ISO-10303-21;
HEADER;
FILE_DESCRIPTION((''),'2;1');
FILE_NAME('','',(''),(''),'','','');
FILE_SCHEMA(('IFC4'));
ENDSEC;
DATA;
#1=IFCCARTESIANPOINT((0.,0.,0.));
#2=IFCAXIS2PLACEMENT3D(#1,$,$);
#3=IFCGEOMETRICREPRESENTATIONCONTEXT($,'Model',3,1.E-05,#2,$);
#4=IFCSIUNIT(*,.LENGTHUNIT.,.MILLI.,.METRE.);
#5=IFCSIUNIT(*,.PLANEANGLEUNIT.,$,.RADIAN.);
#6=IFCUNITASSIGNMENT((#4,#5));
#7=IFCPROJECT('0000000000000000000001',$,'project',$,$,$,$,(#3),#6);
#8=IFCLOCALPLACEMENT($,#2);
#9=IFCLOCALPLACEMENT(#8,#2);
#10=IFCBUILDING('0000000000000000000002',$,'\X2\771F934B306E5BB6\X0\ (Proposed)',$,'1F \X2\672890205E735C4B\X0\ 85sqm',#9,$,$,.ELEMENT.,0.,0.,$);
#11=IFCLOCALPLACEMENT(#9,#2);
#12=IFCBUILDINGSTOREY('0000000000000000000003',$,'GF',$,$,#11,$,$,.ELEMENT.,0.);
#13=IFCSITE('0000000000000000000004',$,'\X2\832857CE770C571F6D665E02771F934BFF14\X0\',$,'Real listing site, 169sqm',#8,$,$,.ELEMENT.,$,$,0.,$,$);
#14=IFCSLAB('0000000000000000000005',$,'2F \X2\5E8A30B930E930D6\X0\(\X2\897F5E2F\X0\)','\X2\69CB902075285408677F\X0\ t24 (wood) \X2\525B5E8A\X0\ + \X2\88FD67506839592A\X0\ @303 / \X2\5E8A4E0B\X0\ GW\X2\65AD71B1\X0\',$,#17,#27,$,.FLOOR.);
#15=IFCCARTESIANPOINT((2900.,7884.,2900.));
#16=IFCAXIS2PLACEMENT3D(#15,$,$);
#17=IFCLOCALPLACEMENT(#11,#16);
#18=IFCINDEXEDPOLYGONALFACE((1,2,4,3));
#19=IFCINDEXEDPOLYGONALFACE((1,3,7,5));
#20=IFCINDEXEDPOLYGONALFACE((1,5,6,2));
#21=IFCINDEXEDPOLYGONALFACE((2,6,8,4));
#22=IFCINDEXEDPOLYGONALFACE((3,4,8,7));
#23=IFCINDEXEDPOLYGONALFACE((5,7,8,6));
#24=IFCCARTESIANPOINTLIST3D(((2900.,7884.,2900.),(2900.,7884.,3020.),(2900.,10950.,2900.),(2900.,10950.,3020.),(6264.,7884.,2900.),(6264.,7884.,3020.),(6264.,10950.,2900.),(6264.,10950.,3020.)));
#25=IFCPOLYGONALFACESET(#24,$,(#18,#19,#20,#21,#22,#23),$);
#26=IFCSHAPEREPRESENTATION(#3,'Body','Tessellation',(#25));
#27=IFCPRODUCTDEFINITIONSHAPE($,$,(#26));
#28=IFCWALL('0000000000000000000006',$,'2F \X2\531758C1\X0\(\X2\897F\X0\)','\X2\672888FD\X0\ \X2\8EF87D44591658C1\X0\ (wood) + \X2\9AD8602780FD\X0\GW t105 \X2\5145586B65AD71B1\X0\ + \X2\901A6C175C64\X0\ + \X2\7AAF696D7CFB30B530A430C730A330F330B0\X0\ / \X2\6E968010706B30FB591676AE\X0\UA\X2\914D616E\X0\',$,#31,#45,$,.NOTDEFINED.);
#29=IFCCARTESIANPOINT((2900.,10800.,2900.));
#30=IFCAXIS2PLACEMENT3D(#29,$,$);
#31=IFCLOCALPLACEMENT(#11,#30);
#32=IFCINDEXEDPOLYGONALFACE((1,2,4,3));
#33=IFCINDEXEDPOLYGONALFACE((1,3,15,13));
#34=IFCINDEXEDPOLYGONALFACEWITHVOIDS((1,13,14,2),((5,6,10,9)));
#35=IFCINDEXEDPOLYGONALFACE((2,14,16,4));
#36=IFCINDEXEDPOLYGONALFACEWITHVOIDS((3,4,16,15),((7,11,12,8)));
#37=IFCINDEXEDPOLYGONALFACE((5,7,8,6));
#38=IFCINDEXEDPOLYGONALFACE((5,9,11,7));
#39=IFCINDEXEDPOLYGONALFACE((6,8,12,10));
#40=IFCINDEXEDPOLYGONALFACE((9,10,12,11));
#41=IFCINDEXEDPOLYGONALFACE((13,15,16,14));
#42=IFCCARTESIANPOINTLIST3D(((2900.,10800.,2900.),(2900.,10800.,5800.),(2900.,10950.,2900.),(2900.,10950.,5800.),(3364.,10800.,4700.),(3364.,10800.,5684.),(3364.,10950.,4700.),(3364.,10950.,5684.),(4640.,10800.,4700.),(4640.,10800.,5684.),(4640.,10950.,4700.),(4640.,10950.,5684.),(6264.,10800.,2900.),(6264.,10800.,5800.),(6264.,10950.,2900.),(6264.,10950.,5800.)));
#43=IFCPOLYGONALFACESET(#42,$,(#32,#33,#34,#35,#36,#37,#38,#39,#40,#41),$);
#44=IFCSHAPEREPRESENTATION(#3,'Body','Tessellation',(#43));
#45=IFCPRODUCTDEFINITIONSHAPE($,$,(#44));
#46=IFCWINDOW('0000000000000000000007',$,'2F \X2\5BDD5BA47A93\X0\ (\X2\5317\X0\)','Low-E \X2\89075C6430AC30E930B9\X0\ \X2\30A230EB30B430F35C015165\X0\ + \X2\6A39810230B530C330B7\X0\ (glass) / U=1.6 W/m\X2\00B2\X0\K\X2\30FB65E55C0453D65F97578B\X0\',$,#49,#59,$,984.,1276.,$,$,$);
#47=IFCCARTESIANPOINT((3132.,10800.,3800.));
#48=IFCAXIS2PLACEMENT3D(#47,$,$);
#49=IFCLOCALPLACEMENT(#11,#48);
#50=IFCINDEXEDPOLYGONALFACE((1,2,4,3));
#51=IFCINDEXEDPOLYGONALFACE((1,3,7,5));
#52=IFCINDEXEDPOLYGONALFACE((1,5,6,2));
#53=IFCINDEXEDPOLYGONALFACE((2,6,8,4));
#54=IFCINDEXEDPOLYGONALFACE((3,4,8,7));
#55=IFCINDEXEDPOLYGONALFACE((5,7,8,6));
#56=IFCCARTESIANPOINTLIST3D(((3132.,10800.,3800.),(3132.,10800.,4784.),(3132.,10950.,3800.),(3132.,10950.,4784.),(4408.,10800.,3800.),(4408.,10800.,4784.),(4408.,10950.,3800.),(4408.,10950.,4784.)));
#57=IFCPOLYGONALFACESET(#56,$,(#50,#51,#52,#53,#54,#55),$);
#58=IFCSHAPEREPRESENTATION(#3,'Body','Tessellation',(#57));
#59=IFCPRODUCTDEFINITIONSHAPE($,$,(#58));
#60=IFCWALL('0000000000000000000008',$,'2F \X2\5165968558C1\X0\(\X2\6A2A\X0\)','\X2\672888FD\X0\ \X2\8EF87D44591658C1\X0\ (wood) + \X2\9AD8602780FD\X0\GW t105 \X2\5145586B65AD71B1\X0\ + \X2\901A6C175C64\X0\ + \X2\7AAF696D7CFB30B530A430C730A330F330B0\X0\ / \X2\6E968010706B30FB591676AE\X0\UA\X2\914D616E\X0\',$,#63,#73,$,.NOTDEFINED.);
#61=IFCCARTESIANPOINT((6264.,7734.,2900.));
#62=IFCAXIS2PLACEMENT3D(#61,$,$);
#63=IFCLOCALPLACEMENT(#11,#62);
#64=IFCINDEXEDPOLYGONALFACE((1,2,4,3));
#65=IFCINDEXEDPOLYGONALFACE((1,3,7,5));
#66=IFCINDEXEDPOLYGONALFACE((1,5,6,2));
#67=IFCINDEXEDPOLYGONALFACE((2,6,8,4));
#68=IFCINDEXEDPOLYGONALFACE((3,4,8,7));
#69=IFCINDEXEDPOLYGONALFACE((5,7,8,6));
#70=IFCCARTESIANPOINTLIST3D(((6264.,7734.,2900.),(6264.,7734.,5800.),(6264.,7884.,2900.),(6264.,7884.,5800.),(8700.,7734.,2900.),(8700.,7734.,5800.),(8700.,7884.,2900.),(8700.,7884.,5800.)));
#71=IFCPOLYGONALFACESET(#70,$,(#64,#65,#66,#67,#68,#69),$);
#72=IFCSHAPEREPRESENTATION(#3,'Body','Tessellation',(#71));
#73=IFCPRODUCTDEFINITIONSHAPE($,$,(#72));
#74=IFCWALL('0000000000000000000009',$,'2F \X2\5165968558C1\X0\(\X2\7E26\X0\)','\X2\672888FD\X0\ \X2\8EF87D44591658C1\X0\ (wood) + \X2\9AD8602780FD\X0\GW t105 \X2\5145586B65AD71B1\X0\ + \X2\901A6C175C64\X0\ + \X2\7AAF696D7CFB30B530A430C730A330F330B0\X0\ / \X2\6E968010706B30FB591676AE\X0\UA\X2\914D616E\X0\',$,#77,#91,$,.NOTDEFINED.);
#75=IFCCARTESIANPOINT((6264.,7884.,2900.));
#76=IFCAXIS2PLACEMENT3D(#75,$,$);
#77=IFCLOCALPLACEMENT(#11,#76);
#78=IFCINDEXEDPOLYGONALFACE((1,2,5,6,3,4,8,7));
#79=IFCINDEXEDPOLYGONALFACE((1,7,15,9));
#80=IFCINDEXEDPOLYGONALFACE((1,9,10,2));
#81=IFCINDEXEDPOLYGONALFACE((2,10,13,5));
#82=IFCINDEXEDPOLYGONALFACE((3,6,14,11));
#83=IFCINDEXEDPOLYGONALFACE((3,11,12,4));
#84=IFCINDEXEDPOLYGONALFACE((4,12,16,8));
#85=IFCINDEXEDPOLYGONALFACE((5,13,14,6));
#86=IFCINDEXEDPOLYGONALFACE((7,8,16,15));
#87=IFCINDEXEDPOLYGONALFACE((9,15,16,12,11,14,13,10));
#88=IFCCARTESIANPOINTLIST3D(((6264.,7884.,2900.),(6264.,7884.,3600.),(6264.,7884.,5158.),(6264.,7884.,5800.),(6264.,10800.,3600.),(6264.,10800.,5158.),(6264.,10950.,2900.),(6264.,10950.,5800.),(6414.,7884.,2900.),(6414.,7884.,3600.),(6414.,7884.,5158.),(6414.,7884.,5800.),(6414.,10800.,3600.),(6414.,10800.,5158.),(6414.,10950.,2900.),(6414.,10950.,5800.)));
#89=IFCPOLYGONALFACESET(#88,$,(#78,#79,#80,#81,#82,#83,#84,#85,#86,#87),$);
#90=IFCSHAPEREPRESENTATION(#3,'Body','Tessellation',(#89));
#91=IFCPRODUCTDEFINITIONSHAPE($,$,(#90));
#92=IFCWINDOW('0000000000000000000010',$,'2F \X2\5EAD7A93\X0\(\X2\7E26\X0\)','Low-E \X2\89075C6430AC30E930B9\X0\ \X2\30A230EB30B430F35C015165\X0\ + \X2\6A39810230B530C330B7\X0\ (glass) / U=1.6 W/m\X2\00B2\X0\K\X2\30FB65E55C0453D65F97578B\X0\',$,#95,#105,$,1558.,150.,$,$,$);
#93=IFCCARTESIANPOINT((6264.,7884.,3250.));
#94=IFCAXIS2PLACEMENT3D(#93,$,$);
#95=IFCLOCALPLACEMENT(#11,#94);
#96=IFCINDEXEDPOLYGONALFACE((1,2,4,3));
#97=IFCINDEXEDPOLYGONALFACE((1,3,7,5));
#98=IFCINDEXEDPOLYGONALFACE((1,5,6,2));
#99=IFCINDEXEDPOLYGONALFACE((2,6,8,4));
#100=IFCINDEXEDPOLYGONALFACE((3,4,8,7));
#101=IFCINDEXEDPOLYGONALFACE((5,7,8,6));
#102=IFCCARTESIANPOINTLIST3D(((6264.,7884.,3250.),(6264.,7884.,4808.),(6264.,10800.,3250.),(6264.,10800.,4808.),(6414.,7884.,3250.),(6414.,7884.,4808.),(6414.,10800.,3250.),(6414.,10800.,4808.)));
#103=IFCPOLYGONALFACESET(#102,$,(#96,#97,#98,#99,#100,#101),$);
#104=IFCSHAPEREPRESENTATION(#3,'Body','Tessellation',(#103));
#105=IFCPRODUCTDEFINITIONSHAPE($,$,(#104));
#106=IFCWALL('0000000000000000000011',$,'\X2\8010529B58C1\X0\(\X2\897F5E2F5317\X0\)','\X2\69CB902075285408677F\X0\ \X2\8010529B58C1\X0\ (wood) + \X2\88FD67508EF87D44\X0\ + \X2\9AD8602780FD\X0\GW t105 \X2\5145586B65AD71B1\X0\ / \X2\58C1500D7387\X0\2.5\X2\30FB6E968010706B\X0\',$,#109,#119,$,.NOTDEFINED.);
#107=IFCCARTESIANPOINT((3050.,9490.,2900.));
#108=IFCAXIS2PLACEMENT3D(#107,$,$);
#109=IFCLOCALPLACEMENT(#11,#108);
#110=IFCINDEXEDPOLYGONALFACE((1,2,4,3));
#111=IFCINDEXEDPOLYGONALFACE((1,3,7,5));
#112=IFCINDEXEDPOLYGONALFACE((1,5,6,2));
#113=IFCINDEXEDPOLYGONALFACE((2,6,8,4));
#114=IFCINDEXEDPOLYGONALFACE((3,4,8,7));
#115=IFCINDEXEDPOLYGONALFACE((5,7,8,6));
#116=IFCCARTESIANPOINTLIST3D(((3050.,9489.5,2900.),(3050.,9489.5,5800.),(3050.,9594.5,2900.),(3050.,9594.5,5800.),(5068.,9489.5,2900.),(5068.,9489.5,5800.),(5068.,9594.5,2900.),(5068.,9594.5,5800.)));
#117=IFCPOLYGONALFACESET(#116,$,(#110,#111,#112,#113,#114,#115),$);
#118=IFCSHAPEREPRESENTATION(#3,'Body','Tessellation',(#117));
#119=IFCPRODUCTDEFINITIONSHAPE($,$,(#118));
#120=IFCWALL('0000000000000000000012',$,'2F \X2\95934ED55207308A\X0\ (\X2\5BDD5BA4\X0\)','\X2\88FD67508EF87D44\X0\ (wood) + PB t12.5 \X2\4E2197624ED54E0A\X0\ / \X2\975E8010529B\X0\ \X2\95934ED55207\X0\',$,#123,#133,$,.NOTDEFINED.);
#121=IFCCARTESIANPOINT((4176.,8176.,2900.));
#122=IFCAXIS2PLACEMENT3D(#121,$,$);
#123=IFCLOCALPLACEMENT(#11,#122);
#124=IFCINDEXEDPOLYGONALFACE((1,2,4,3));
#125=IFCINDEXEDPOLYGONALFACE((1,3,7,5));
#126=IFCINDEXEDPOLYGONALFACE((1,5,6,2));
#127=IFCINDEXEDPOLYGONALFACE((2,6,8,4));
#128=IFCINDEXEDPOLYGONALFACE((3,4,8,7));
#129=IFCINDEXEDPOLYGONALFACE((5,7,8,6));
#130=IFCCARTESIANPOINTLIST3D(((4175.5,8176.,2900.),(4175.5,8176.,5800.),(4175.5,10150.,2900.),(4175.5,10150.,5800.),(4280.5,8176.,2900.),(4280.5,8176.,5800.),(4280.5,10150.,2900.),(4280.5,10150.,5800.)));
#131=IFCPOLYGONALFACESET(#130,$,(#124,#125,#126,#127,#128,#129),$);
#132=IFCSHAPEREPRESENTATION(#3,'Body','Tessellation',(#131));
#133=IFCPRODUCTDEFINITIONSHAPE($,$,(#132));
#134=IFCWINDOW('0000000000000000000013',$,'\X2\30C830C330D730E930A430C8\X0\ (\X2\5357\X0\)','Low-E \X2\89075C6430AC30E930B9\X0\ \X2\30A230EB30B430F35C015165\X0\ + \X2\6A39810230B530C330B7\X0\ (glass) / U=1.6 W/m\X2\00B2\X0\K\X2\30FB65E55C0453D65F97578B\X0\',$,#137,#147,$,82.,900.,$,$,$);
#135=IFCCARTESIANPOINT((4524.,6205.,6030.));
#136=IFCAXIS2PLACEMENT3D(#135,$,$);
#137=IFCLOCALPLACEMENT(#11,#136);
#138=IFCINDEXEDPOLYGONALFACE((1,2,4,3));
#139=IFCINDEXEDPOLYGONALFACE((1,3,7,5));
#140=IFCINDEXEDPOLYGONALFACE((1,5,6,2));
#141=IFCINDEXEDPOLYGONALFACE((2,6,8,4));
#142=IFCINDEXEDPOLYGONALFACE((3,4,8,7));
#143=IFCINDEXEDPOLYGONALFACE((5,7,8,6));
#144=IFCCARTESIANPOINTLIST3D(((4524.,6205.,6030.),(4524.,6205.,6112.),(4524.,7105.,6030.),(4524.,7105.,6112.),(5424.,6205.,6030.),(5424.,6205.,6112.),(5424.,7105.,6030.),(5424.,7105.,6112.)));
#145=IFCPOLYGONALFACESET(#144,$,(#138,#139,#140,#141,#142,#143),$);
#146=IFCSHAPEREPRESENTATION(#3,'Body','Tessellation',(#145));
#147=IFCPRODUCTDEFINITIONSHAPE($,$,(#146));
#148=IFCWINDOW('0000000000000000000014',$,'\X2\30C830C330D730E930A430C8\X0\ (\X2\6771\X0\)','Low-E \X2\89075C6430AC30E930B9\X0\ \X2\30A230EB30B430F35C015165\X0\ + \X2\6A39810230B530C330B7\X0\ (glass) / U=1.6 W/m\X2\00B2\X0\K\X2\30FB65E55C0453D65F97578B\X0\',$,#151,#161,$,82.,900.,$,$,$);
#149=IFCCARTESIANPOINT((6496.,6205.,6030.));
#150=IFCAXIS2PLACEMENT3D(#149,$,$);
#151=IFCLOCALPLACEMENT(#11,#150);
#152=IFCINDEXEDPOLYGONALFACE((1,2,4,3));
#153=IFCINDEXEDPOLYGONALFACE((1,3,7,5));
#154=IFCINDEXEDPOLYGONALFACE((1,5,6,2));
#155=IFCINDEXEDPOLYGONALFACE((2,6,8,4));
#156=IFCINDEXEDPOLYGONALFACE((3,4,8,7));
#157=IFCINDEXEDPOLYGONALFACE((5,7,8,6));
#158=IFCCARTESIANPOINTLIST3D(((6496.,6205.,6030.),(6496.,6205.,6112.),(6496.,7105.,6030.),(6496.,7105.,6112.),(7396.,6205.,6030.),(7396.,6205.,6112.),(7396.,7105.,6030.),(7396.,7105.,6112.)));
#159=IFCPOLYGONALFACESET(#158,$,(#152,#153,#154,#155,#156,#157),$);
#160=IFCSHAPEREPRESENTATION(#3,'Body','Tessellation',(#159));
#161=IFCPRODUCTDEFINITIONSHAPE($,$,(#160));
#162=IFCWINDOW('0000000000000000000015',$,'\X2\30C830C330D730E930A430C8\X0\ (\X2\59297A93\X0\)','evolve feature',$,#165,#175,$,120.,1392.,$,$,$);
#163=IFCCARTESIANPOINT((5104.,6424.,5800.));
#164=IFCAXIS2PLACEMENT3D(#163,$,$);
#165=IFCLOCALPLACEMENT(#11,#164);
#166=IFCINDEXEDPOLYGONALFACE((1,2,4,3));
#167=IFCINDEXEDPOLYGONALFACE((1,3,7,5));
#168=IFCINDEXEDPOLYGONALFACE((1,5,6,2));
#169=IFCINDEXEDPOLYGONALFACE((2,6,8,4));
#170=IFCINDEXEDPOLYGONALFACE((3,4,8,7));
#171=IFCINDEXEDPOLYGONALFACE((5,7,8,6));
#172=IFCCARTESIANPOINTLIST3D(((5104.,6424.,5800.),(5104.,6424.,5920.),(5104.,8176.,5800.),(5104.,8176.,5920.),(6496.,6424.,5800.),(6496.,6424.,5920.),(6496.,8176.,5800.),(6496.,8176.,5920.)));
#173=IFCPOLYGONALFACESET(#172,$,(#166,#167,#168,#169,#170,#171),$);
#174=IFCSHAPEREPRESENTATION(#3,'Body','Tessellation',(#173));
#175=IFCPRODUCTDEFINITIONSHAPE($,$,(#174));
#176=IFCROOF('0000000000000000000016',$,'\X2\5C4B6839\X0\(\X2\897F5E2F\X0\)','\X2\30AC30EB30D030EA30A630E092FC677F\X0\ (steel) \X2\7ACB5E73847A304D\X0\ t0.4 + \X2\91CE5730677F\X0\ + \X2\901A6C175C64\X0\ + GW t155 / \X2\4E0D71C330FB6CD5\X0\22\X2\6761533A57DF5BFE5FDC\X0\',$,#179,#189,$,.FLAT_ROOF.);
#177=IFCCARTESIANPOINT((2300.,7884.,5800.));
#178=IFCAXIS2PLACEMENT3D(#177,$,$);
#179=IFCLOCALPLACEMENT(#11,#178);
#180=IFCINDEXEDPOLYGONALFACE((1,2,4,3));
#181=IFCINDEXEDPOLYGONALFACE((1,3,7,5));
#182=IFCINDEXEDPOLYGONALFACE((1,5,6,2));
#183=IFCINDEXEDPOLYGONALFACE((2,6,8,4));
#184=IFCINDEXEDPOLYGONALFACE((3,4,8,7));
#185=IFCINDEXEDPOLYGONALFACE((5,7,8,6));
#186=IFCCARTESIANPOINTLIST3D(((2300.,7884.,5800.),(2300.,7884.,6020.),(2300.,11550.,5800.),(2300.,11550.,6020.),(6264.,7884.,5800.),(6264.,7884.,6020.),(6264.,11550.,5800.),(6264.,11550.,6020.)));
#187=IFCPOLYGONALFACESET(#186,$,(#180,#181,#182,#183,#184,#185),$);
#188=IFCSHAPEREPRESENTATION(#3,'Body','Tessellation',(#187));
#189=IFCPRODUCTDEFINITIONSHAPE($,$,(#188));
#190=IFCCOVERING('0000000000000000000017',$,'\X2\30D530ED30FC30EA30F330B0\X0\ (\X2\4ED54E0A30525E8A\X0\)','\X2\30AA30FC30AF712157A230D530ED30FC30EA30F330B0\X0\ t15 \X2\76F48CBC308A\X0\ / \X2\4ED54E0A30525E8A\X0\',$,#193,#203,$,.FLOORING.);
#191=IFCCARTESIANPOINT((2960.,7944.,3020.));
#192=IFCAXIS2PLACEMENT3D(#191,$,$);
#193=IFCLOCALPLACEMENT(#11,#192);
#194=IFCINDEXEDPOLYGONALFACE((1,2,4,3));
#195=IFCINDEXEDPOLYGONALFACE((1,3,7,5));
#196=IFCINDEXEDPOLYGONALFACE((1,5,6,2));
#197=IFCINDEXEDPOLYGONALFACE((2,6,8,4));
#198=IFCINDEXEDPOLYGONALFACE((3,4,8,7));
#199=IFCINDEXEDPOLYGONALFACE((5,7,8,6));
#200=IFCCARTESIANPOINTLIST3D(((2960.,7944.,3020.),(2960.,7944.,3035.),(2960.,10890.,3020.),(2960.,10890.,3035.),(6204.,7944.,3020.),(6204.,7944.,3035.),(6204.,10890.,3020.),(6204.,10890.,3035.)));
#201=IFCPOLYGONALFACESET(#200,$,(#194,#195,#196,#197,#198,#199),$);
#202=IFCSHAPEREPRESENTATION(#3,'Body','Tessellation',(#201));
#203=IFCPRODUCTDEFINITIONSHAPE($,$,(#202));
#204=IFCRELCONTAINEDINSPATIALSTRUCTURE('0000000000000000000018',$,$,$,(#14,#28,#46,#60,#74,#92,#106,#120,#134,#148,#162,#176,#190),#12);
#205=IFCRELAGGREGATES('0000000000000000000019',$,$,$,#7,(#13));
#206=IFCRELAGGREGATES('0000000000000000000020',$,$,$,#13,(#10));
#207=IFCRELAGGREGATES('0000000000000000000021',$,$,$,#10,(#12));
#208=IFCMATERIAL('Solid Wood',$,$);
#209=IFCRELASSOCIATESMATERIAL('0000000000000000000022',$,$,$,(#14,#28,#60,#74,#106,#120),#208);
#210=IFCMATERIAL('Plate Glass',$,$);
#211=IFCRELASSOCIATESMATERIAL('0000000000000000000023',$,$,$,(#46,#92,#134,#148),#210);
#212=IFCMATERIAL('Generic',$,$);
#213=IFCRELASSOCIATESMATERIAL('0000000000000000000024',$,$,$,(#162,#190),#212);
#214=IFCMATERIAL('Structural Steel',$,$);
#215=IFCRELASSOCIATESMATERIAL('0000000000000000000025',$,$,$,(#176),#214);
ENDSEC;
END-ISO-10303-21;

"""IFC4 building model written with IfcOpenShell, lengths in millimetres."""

from ifc_helpers import new_model, si_unit, frame, frame_2d, origin, place, context, project, spatial, rectangle, extrude, material, element, fill, save


model = new_model("IFC4")

# Units and contexts
model_context = context("Model", 3, precision=1e-05, world=origin())
ifc_project = project(units=[si_unit("LENGTHUNIT", "METRE", prefix="MILLI"), si_unit("PLANEANGLEUNIT", "RADIAN")], contexts=[model_context])

# Site, building, storey
site_placement = place(None, origin())
site = spatial("IfcSite", under=ifc_project, at=site_placement, Name="茨城県土浦市真鍋４", ObjectType="Real listing site, 169sqm", CompositionType="ELEMENT", RefElevation=0.0)
building_placement = place(site_placement, origin())
building = spatial("IfcBuilding", under=site, at=building_placement, Name="真鍋の家 (Proposed)", ObjectType="1F 木造平屋 85sqm", CompositionType="ELEMENT", ElevationOfRefHeight=0.0, ElevationOfTerrain=0.0)
storey_placement = place(building_placement, origin())
storey = spatial("IfcBuildingStorey", under=building, at=storey_placement, Name="GF", CompositionType="ELEMENT", Elevation=0.0)

# Slab
ifc_material_1 = material(Name="Solid Wood")
slab_placement = place(storey_placement, frame((2900.0, 7884.0, 2900.0)))
element("IfcSlab", 1, at=slab_placement, inside=storey, material=ifc_material_1, Name="2F 床スラブ(西帯)", Description="構造用合板 t24 (wood) 剛床 + 製材根太 @303 / 床下 GW断熱", PredefinedType="FLOOR", context=model_context, shape_type="SweptSolid", body=[
    extrude(rectangle(XDim=3364.0, YDim=3066.0, at=frame_2d((1682.0, 1533.0))), frame((2900.0, 7884.0, 2900.0)), (0.0, 0.0, 1.0), 120.0),
])

# Wall, opening, window
wall_1_placement = place(storey_placement, frame((2900.0, 10800.0, 2900.0)))
wall_1 = element("IfcWall", 2, at=wall_1_placement, inside=storey, material=ifc_material_1, Name="2F 北壁(西)", Description="木製 軸組外壁 (wood) + 高性能GW t105 充填断熱 + 通気層 + 窯業系サイディング / 準耐火・外皮UA配慮", PredefinedType="NOTDEFINED", context=model_context, shape_type="SweptSolid", body=[
    extrude(rectangle(XDim=3364.0, YDim=150.0, at=frame_2d((1682.0, 75.0))), frame((2900.0, 10800.0, 2900.0)), (0.0, 0.0, 1.0), 2900.0),
])
opening_1_placement = place(storey_placement, frame((3132.0, 10800.0, 3800.0)))
opening_1 = element("IfcOpeningElement", 3, at=opening_1_placement, cuts=wall_1, PredefinedType="NOTDEFINED", context=model_context, shape_type="SweptSolid", body=[
    extrude(rectangle(XDim=1276.0, YDim=150.0, at=frame_2d((638.0, 75.0))), frame((3132.0, 10800.0, 3800.0)), (0.0, 0.0, 1.0), 984.0),
])
ifc_material_2 = material(Name="Plate Glass")
window_1_placement = place(storey_placement, frame((3132.0, 10800.0, 3800.0)))
window_1 = element("IfcWindow", 4, at=window_1_placement, inside=storey, material=ifc_material_2, Name="2F 寝室窓 (北)", Description="Low-E 複層ガラス アルゴン封入 + 樹脂サッシ (glass) / U=1.6 W/m²K・日射取得型", OverallHeight=984.0, OverallWidth=1276.0, context=model_context, shape_type="SweptSolid", body=[
    extrude(rectangle(XDim=1276.0, YDim=150.0, at=frame_2d((638.0, 75.0))), frame((3132.0, 10800.0, 3800.0)), (0.0, 0.0, 1.0), 984.0),
])
fill(opening_1, window_1)

# Wall
wall_2_placement = place(storey_placement, frame((6264.0, 7734.0, 2900.0)))
element("IfcWall", 5, at=wall_2_placement, inside=storey, material=ifc_material_1, Name="2F 入隅壁(横)", Description="木製 軸組外壁 (wood) + 高性能GW t105 充填断熱 + 通気層 + 窯業系サイディング / 準耐火・外皮UA配慮", PredefinedType="NOTDEFINED", context=model_context, shape_type="SweptSolid", body=[
    extrude(rectangle(XDim=2436.0, YDim=150.0, at=frame_2d((1218.0, 75.0))), frame((6264.0, 7734.0, 2900.0)), (0.0, 0.0, 1.0), 2900.0),
])

# Wall, opening, window
wall_3_placement = place(storey_placement, frame((6264.0, 7884.0, 2900.0)))
wall_3 = element("IfcWall", 6, at=wall_3_placement, inside=storey, material=ifc_material_1, Name="2F 入隅壁(縦)", Description="木製 軸組外壁 (wood) + 高性能GW t105 充填断熱 + 通気層 + 窯業系サイディング / 準耐火・外皮UA配慮", PredefinedType="NOTDEFINED", context=model_context, shape_type="SweptSolid", body=[
    extrude(rectangle(XDim=150.0, YDim=3066.0, at=frame_2d((75.0, 1533.0))), frame((6264.0, 7884.0, 2900.0)), (0.0, 0.0, 1.0), 2900.0),
])
opening_2_placement = place(storey_placement, frame((6264.0, 7884.0, 3250.0)))
opening_2 = element("IfcOpeningElement", 7, at=opening_2_placement, cuts=wall_3, PredefinedType="NOTDEFINED", context=model_context, shape_type="SweptSolid", body=[
    extrude(rectangle(XDim=150.0, YDim=2916.0, at=frame_2d((75.0, 1458.0))), frame((6264.0, 7884.0, 3250.0)), (0.0, 0.0, 1.0), 1558.0),
])
window_2_placement = place(storey_placement, frame((6264.0, 7884.0, 3250.0)))
window_2 = element("IfcWindow", 8, at=window_2_placement, inside=storey, material=ifc_material_2, Name="2F 庭窓(縦)", Description="Low-E 複層ガラス アルゴン封入 + 樹脂サッシ (glass) / U=1.6 W/m²K・日射取得型", OverallHeight=1558.0, OverallWidth=150.0, context=model_context, shape_type="SweptSolid", body=[
    extrude(rectangle(XDim=150.0, YDim=2916.0, at=frame_2d((75.0, 1458.0))), frame((6264.0, 7884.0, 3250.0)), (0.0, 0.0, 1.0), 1558.0),
])
fill(opening_2, window_2)

# Walls
wall_4_placement = place(storey_placement, frame((3050.0, 9490.0, 2900.0)))
element("IfcWall", 9, at=wall_4_placement, inside=storey, material=ifc_material_1, Name="耐力壁(西帯北)", Description="構造用合板 耐力壁 (wood) + 製材軸組 + 高性能GW t105 充填断熱 / 壁倍率2.5・準耐火", PredefinedType="NOTDEFINED", context=model_context, shape_type="SweptSolid", body=[
    extrude(rectangle(XDim=2018.0, YDim=105.0, at=frame_2d((1009.0, 52.0))), frame((3050.0, 9490.0, 2900.0)), (0.0, 0.0, 1.0), 2900.0),
])
wall_5_placement = place(storey_placement, frame((4176.0, 8176.0, 2900.0)))
element("IfcWall", 10, at=wall_5_placement, inside=storey, material=ifc_material_1, Name="2F 間仕切り (寝室)", Description="製材軸組 (wood) + PB t12.5 両面仕上 / 非耐力 間仕切", PredefinedType="NOTDEFINED", context=model_context, shape_type="SweptSolid", body=[
    extrude(rectangle(XDim=105.0, YDim=1974.0, at=frame_2d((52.0, 987.0))), frame((4176.0, 8176.0, 2900.0)), (0.0, 0.0, 1.0), 2900.0),
])

# Windows
window_3_placement = place(storey_placement, frame((4524.0, 6205.0, 6030.0)))
element("IfcWindow", 11, at=window_3_placement, inside=storey, material=ifc_material_2, Name="トップライト (南)", Description="Low-E 複層ガラス アルゴン封入 + 樹脂サッシ (glass) / U=1.6 W/m²K・日射取得型", OverallHeight=82.0, OverallWidth=900.0, context=model_context, shape_type="SweptSolid", body=[
    extrude(rectangle(XDim=900.0, YDim=900.0, at=frame_2d((450.0, 450.0))), frame((4524.0, 6205.0, 6030.0)), (0.0, 0.0, 1.0), 82.0),
])
window_4_placement = place(storey_placement, frame((6496.0, 6205.0, 6030.0)))
element("IfcWindow", 12, at=window_4_placement, inside=storey, material=ifc_material_2, Name="トップライト (東)", Description="Low-E 複層ガラス アルゴン封入 + 樹脂サッシ (glass) / U=1.6 W/m²K・日射取得型", OverallHeight=82.0, OverallWidth=900.0, context=model_context, shape_type="SweptSolid", body=[
    extrude(rectangle(XDim=900.0, YDim=900.0, at=frame_2d((450.0, 450.0))), frame((6496.0, 6205.0, 6030.0)), (0.0, 0.0, 1.0), 82.0),
])
ifc_material_3 = material(Name="Generic")
window_5_placement = place(storey_placement, frame((5104.0, 6424.0, 5800.0)))
element("IfcWindow", 13, at=window_5_placement, inside=storey, material=ifc_material_3, Name="トップライト (天窓)", Description="evolve feature", OverallHeight=120.0, OverallWidth=1392.0, context=model_context, shape_type="SweptSolid", body=[
    extrude(rectangle(XDim=1392.0, YDim=1752.0, at=frame_2d((696.0, 876.0))), frame((5104.0, 6424.0, 5800.0)), (0.0, 0.0, 1.0), 120.0),
])

# Roof
ifc_material_4 = material(Name="Structural Steel")
for number, where, name in (
    (14, (2300.0, 7884.0, 5800.0), "屋根(西帯)"),
):
    element("IfcRoof", number, at=place(storey_placement, frame(where)), inside=storey, material=ifc_material_4, Name=name, Description="ガルバリウム鋼板 (steel) 立平葺き t0.4 + 野地板 + 通気層 + GW t155 / 不燃・法22条区域対応", PredefinedType="FLAT_ROOF", context=model_context, shape_type="SweptSolid", body=[
        extrude(rectangle(XDim=3964.0, YDim=3666.0, at=frame_2d((1982.0, 1833.0))), frame((2300.0, 7884.0, 5800.0)), (0.0, 0.0, 1.0), 220.0),
    ])

# Covering
covering_placement = place(storey_placement, frame((2960.0, 7944.0, 3020.0)))
element("IfcCovering", 15, at=covering_placement, inside=storey, material=ifc_material_3, Name="フローリング (仕上げ床)", Description="オーク無垢フローリング t15 直貼り / 仕上げ床", PredefinedType="FLOORING", context=model_context, shape_type="SweptSolid", body=[
    extrude(rectangle(XDim=3244.0, YDim=2946.0, at=frame_2d((1622.0, 1473.0))), frame((2960.0, 7944.0, 3020.0)), (0.0, 0.0, 1.0), 15.0),
])

save(model, "model.ifc")
